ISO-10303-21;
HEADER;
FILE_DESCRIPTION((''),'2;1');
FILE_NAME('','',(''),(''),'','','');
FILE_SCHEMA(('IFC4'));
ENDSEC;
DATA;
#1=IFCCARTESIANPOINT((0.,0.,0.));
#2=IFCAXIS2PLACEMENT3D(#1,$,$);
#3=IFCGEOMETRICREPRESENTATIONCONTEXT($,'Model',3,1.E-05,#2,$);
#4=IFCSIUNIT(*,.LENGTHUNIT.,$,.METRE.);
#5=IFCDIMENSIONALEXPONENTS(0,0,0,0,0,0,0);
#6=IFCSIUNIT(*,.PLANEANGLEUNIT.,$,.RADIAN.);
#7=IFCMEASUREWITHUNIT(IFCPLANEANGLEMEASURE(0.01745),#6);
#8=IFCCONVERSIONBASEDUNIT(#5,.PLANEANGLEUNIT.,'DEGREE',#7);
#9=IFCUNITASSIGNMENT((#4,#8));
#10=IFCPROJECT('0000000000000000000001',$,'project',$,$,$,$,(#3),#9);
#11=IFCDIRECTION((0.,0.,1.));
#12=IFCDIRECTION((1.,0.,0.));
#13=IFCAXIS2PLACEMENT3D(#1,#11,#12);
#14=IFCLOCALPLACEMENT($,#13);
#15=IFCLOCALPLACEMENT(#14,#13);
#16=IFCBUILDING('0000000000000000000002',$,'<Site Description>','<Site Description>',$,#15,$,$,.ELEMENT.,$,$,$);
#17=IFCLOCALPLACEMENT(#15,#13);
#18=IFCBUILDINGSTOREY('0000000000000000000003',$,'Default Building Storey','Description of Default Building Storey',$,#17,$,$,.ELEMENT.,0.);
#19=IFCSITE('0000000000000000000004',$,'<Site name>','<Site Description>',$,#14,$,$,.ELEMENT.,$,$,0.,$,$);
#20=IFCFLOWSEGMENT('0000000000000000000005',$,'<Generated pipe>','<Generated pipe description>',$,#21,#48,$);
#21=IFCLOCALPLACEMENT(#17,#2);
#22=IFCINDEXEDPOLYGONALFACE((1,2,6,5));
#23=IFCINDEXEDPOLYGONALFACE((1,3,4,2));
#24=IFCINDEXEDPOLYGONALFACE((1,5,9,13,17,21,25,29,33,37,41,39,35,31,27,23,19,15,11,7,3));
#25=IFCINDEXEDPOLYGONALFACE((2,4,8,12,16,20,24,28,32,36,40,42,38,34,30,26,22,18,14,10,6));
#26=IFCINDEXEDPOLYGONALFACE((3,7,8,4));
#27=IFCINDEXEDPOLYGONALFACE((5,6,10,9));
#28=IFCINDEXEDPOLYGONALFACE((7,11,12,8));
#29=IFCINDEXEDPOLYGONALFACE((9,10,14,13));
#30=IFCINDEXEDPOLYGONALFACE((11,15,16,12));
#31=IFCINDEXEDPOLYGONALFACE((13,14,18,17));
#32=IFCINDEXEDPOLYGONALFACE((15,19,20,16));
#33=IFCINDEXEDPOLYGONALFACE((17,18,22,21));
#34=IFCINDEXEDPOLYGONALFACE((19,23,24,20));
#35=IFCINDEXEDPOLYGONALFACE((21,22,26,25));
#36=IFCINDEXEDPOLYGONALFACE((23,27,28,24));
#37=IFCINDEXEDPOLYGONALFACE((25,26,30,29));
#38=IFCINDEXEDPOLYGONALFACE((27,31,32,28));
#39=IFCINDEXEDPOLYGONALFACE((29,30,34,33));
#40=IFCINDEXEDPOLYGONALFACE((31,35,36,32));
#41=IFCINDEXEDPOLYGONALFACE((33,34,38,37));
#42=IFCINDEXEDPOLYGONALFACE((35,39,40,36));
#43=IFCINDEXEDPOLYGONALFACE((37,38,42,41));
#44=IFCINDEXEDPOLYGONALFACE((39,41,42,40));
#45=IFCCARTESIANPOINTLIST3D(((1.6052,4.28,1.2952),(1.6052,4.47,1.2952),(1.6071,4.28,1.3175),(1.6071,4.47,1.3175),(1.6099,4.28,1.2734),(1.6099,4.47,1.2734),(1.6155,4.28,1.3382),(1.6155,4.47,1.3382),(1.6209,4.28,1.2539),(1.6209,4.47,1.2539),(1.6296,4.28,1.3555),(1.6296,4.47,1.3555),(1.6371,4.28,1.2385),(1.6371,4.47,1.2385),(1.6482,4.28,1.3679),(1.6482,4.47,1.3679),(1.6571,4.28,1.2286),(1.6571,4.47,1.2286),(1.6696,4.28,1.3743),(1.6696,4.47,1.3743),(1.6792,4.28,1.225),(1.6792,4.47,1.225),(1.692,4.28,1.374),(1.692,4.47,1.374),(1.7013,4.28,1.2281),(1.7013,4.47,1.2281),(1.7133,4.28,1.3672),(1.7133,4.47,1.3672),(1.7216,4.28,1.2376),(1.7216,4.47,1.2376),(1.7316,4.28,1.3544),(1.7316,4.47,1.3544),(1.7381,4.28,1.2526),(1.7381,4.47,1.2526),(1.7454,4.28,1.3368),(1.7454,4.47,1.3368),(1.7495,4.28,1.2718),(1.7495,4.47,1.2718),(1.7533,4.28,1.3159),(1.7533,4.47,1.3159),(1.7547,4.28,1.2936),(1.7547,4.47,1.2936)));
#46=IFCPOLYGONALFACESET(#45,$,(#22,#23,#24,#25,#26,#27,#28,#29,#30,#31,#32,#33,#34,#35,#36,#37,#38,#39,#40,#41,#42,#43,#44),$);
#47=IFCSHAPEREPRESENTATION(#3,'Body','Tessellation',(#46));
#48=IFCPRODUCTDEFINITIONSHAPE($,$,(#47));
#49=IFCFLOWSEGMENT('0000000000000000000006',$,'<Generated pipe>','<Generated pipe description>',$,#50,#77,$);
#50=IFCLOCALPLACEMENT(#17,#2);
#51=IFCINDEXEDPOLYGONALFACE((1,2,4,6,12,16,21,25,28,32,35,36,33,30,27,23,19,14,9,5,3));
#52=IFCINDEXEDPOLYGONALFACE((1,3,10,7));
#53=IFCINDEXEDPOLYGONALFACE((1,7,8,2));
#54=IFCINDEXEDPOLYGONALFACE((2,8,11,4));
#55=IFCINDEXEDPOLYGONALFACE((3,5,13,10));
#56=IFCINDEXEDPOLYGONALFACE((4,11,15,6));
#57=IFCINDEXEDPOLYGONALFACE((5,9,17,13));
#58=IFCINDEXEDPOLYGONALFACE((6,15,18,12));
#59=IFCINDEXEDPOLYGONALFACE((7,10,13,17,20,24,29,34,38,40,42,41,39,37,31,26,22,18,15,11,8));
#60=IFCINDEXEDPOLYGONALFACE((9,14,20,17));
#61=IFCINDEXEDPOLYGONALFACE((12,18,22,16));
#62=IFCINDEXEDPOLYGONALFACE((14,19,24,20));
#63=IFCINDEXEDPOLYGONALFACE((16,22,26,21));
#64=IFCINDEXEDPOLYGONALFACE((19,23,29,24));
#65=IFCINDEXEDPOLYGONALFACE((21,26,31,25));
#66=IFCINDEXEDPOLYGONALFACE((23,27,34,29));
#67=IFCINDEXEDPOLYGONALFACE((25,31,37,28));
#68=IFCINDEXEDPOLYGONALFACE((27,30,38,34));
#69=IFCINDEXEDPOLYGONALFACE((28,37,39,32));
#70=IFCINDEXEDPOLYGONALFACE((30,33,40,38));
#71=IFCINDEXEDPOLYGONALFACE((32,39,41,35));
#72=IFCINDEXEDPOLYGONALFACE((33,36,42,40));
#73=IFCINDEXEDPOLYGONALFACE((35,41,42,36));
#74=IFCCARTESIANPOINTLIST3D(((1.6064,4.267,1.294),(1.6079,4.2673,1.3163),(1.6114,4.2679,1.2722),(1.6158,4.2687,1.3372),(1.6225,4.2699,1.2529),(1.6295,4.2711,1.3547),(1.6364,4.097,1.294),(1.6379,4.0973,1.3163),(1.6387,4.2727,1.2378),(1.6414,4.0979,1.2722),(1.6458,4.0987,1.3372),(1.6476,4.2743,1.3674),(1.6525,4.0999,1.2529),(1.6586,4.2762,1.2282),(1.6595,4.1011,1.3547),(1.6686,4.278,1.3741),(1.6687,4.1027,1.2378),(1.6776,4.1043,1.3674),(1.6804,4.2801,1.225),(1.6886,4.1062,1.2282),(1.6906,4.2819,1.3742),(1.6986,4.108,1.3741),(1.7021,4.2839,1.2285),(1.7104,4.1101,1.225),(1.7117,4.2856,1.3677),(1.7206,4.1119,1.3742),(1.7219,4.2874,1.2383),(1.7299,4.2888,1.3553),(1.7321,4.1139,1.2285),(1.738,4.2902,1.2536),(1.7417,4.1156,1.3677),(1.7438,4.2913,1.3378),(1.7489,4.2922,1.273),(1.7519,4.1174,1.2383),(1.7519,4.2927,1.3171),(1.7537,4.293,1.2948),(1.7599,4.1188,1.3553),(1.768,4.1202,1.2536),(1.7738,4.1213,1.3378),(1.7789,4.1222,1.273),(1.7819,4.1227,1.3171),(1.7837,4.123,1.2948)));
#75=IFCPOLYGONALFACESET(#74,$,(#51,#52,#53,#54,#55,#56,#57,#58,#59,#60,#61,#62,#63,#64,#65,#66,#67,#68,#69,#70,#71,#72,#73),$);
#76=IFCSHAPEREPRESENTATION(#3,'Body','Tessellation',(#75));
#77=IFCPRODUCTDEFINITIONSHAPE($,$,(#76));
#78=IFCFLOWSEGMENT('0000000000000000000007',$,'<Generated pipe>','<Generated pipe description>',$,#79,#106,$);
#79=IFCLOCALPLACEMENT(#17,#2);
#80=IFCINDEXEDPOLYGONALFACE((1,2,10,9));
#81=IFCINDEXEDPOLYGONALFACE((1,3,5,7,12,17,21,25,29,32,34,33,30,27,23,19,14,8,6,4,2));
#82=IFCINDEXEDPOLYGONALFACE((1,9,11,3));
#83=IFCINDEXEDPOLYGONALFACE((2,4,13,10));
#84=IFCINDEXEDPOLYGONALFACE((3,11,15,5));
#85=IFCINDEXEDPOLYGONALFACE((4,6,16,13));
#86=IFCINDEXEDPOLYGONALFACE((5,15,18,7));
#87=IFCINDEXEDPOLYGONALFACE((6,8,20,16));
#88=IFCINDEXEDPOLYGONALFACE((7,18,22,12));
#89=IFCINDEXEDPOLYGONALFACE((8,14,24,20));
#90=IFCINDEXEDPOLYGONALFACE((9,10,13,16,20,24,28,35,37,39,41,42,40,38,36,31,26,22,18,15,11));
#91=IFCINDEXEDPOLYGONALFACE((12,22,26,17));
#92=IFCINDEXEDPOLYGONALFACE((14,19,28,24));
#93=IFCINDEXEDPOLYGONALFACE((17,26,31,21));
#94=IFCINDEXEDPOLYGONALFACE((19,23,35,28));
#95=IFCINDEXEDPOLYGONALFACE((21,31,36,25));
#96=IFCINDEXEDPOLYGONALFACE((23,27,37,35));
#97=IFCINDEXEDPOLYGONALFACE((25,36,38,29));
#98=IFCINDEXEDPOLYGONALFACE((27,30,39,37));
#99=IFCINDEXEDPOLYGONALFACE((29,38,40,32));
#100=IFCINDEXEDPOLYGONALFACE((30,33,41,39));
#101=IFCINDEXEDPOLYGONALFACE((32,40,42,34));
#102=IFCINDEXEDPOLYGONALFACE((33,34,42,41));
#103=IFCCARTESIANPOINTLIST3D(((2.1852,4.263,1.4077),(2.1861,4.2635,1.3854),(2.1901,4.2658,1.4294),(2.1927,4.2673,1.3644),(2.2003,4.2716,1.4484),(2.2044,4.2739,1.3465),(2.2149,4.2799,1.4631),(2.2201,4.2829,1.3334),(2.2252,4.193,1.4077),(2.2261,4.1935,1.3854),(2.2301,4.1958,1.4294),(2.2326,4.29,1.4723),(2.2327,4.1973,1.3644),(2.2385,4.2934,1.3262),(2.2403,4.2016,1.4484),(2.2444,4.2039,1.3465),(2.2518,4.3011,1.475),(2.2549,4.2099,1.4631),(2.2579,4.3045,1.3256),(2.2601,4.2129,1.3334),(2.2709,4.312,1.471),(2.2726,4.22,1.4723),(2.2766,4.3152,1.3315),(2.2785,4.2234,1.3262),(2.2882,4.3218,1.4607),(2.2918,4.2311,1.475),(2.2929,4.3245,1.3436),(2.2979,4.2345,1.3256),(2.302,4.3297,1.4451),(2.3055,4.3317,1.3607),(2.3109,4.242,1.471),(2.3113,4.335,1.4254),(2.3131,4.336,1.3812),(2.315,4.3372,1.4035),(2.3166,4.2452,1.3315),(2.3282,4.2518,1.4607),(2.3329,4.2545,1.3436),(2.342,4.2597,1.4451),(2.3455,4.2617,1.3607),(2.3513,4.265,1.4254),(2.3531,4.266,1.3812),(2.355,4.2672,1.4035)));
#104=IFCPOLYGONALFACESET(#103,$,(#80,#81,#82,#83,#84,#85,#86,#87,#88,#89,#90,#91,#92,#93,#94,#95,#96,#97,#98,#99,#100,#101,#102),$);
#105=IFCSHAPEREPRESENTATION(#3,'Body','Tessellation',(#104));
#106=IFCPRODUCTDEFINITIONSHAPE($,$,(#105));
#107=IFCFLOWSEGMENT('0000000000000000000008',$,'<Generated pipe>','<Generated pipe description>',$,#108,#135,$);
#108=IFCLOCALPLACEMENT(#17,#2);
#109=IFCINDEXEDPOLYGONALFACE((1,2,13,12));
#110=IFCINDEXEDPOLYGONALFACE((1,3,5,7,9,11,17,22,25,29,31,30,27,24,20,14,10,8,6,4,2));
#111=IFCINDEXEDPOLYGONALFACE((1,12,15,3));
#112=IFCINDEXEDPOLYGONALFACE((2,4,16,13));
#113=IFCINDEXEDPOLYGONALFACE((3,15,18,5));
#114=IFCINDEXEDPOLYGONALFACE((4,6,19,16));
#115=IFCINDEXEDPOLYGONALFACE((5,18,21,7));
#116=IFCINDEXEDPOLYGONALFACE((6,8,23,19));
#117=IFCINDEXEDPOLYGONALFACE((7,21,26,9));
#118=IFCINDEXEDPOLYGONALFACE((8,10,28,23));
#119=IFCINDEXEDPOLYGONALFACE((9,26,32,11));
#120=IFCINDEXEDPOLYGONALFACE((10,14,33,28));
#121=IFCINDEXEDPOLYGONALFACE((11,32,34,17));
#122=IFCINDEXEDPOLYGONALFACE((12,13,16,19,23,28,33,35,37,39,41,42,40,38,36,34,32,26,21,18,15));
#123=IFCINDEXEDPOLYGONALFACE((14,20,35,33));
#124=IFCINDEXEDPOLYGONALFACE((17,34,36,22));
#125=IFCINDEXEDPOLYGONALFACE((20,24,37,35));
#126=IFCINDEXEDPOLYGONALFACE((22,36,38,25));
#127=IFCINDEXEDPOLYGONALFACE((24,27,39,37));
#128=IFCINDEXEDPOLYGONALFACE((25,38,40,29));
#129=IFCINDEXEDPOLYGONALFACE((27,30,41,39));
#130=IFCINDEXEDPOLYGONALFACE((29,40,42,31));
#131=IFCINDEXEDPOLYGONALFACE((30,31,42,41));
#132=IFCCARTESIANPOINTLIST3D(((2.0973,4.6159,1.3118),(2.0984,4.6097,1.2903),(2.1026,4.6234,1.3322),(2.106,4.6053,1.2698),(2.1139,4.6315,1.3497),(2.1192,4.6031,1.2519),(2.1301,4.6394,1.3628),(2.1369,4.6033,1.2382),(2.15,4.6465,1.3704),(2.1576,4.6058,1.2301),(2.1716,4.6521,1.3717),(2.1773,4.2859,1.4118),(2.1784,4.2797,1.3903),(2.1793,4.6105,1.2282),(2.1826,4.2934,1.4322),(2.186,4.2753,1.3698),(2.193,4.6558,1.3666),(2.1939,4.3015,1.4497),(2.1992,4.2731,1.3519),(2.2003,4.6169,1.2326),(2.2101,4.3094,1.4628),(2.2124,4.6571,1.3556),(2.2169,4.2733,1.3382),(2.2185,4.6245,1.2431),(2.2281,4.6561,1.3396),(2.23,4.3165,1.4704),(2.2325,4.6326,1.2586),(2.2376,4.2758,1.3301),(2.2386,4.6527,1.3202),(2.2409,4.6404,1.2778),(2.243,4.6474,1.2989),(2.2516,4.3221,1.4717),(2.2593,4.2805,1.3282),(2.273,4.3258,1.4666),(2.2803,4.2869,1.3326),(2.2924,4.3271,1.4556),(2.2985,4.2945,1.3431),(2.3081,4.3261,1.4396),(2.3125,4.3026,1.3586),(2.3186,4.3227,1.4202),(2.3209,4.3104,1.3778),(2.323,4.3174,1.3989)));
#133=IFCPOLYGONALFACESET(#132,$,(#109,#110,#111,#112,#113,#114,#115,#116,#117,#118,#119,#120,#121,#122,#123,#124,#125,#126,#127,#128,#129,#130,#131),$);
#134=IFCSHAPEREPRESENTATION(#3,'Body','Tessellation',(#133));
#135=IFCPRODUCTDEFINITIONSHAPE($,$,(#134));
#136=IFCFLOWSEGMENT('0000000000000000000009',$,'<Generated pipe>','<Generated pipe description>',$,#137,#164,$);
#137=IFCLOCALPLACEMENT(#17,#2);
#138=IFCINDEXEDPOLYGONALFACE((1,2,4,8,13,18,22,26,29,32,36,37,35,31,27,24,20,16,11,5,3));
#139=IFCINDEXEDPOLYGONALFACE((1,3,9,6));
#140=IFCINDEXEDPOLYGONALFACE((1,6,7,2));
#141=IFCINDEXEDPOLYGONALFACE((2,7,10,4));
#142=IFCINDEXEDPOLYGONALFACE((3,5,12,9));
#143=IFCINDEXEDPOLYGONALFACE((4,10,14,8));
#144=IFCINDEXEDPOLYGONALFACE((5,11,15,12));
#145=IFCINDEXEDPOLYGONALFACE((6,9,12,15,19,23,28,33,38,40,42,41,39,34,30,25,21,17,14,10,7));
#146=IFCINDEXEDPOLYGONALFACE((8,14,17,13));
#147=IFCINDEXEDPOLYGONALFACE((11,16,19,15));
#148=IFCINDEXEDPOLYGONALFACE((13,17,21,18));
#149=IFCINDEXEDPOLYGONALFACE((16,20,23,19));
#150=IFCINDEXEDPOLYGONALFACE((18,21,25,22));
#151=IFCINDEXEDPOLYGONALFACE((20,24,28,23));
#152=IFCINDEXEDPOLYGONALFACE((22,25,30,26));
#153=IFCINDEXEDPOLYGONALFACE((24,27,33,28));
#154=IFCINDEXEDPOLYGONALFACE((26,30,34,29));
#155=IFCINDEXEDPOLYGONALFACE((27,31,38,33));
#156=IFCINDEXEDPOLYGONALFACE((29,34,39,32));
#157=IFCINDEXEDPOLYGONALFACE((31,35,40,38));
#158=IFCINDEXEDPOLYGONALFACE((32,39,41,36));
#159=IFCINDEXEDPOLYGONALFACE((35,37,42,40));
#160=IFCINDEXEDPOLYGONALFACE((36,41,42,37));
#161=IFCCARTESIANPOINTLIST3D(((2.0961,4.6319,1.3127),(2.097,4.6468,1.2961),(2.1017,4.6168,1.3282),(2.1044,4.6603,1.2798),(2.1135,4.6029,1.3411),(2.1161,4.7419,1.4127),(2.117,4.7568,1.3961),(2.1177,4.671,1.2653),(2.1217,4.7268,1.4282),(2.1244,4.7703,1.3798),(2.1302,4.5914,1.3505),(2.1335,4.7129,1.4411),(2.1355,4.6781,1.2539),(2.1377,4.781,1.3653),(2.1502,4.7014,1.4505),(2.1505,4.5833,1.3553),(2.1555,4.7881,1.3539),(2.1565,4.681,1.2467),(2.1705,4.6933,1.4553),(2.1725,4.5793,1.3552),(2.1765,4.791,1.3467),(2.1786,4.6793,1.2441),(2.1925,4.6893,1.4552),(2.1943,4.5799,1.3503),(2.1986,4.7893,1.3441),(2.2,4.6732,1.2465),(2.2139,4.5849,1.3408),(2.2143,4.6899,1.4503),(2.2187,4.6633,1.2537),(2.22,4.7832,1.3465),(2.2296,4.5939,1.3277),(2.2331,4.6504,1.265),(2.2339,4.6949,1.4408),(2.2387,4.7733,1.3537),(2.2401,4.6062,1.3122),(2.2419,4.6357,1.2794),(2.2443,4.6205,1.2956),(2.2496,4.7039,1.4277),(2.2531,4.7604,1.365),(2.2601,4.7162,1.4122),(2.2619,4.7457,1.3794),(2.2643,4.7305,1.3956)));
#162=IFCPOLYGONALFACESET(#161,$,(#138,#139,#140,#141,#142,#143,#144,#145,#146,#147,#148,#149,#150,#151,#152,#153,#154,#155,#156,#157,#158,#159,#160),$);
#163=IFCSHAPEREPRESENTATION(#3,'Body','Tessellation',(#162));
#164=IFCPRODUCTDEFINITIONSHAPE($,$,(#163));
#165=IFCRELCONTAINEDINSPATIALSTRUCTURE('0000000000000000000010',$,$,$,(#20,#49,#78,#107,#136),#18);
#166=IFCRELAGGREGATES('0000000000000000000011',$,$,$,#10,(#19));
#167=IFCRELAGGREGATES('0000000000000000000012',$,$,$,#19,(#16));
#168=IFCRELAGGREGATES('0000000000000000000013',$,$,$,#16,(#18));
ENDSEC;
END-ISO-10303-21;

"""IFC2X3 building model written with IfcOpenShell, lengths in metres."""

from ifc_helpers import new_model, entity, si_unit, converted_unit, frame, origin, origin_with_axes, origin_2d_with_axis, place, context, project, spatial, circle, extrude, element, save


model = new_model("IFC2X3")

# Units and contexts
model_context = context("Model", 3, precision=1e-05, world=origin())
ifc_project = project(units=[si_unit("LENGTHUNIT", "METRE"), converted_unit("PLANEANGLEUNIT", "DEGREE", entity("IfcPlaneAngleMeasure", 0.01745), si_unit("PLANEANGLEUNIT", "RADIAN"), dimensions=[0, 0, 0, 0, 0, 0, 0])], contexts=[model_context])

# Site, building, storey
site_placement = place(None, origin_with_axes())
site = spatial("IfcSite", under=ifc_project, at=site_placement, Name="<Site name>", Description="<Site Description>", CompositionType="ELEMENT", RefElevation=0.0)
building_placement = place(site_placement, origin_with_axes())
building = spatial("IfcBuilding", under=site, at=building_placement, Name="<Site Description>", Description="<Site Description>", CompositionType="ELEMENT")
storey_placement = place(building_placement, origin_with_axes())
storey = spatial("IfcBuildingStorey", under=building, at=storey_placement, Name="Default Building Storey", Description="Description of Default Building Storey", CompositionType="ELEMENT", Elevation=0.0)

# Flow segments
flow_segment_1_placement = place(storey_placement, frame((1.68, 4.47, 1.3), z_axis=(0.0, -1.0, 0.0), x_axis=(0.871461, 0.0, 0.490464)))
element("IfcFlowSegment", 1, at=flow_segment_1_placement, inside=storey, Name="<Generated pipe>", Description="<Generated pipe description>", context=model_context, shape_type="SweptSolid", body=[
    extrude(circle(Radius=0.075, at=origin_2d_with_axis()), origin_with_axes(), (0.0, 0.0, 1.0), 0.19),
])
flow_segment_2_placement = place(storey_placement, frame((1.68, 4.28, 1.3), z_axis=(0.173785, -0.984784, 0.0), x_axis=(0.665954, 0.117521, 0.736678)))
element("IfcFlowSegment", 2, at=flow_segment_2_placement, inside=storey, Name="<Generated pipe>", Description="<Generated pipe description>", context=model_context, shape_type="SweptSolid", body=[
    extrude(circle(Radius=0.075, at=origin_2d_with_axis()), origin_with_axes(), (0.0, 0.0, 1.0), 0.1726),
])
flow_segment_3_placement = place(storey_placement, frame((2.29, 4.23, 1.4), z_axis=(-0.496139, 0.868243, 0.0), x_axis=(0.693863, 0.396493, 0.601121)))
element("IfcFlowSegment", 3, at=flow_segment_3_placement, inside=storey, Name="<Generated pipe>", Description="<Generated pipe description>", context=model_context, shape_type="SweptSolid", body=[
    extrude(circle(Radius=0.075, at=origin_2d_with_axis()), origin_with_axes(), (0.0, 0.0, 1.0), 0.0806),
])
flow_segment_4_placement = place(storey_placement, frame((2.25, 4.3, 1.4), z_axis=(-0.226003, 0.932263, -0.282504), x_axis=(0.306966, 0.343389, 0.887612)))
element("IfcFlowSegment", 4, at=flow_segment_4_placement, inside=storey, Name="<Generated pipe>", Description="<Generated pipe description>", context=model_context, shape_type="SweptSolid", body=[
    extrude(circle(Radius=0.075, at=origin_2d_with_axis()), origin_with_axes(), (0.0, 0.0, 1.0), 0.354),
])
flow_segment_5_placement = place(storey_placement, frame((2.17, 4.63, 1.3), z_axis=(0.133333, 0.733333, 0.666667), x_axis=(0.323478, -0.668035, 0.670143)))
element("IfcFlowSegment", 5, at=flow_segment_5_placement, inside=storey, Name="<Generated pipe>", Description="<Generated pipe description>", context=model_context, shape_type="SweptSolid", body=[
    extrude(circle(Radius=0.075, at=origin_2d_with_axis()), origin_with_axes(), (0.0, 0.0, 1.0), 0.15),
])

save(model, "model.ifc")
